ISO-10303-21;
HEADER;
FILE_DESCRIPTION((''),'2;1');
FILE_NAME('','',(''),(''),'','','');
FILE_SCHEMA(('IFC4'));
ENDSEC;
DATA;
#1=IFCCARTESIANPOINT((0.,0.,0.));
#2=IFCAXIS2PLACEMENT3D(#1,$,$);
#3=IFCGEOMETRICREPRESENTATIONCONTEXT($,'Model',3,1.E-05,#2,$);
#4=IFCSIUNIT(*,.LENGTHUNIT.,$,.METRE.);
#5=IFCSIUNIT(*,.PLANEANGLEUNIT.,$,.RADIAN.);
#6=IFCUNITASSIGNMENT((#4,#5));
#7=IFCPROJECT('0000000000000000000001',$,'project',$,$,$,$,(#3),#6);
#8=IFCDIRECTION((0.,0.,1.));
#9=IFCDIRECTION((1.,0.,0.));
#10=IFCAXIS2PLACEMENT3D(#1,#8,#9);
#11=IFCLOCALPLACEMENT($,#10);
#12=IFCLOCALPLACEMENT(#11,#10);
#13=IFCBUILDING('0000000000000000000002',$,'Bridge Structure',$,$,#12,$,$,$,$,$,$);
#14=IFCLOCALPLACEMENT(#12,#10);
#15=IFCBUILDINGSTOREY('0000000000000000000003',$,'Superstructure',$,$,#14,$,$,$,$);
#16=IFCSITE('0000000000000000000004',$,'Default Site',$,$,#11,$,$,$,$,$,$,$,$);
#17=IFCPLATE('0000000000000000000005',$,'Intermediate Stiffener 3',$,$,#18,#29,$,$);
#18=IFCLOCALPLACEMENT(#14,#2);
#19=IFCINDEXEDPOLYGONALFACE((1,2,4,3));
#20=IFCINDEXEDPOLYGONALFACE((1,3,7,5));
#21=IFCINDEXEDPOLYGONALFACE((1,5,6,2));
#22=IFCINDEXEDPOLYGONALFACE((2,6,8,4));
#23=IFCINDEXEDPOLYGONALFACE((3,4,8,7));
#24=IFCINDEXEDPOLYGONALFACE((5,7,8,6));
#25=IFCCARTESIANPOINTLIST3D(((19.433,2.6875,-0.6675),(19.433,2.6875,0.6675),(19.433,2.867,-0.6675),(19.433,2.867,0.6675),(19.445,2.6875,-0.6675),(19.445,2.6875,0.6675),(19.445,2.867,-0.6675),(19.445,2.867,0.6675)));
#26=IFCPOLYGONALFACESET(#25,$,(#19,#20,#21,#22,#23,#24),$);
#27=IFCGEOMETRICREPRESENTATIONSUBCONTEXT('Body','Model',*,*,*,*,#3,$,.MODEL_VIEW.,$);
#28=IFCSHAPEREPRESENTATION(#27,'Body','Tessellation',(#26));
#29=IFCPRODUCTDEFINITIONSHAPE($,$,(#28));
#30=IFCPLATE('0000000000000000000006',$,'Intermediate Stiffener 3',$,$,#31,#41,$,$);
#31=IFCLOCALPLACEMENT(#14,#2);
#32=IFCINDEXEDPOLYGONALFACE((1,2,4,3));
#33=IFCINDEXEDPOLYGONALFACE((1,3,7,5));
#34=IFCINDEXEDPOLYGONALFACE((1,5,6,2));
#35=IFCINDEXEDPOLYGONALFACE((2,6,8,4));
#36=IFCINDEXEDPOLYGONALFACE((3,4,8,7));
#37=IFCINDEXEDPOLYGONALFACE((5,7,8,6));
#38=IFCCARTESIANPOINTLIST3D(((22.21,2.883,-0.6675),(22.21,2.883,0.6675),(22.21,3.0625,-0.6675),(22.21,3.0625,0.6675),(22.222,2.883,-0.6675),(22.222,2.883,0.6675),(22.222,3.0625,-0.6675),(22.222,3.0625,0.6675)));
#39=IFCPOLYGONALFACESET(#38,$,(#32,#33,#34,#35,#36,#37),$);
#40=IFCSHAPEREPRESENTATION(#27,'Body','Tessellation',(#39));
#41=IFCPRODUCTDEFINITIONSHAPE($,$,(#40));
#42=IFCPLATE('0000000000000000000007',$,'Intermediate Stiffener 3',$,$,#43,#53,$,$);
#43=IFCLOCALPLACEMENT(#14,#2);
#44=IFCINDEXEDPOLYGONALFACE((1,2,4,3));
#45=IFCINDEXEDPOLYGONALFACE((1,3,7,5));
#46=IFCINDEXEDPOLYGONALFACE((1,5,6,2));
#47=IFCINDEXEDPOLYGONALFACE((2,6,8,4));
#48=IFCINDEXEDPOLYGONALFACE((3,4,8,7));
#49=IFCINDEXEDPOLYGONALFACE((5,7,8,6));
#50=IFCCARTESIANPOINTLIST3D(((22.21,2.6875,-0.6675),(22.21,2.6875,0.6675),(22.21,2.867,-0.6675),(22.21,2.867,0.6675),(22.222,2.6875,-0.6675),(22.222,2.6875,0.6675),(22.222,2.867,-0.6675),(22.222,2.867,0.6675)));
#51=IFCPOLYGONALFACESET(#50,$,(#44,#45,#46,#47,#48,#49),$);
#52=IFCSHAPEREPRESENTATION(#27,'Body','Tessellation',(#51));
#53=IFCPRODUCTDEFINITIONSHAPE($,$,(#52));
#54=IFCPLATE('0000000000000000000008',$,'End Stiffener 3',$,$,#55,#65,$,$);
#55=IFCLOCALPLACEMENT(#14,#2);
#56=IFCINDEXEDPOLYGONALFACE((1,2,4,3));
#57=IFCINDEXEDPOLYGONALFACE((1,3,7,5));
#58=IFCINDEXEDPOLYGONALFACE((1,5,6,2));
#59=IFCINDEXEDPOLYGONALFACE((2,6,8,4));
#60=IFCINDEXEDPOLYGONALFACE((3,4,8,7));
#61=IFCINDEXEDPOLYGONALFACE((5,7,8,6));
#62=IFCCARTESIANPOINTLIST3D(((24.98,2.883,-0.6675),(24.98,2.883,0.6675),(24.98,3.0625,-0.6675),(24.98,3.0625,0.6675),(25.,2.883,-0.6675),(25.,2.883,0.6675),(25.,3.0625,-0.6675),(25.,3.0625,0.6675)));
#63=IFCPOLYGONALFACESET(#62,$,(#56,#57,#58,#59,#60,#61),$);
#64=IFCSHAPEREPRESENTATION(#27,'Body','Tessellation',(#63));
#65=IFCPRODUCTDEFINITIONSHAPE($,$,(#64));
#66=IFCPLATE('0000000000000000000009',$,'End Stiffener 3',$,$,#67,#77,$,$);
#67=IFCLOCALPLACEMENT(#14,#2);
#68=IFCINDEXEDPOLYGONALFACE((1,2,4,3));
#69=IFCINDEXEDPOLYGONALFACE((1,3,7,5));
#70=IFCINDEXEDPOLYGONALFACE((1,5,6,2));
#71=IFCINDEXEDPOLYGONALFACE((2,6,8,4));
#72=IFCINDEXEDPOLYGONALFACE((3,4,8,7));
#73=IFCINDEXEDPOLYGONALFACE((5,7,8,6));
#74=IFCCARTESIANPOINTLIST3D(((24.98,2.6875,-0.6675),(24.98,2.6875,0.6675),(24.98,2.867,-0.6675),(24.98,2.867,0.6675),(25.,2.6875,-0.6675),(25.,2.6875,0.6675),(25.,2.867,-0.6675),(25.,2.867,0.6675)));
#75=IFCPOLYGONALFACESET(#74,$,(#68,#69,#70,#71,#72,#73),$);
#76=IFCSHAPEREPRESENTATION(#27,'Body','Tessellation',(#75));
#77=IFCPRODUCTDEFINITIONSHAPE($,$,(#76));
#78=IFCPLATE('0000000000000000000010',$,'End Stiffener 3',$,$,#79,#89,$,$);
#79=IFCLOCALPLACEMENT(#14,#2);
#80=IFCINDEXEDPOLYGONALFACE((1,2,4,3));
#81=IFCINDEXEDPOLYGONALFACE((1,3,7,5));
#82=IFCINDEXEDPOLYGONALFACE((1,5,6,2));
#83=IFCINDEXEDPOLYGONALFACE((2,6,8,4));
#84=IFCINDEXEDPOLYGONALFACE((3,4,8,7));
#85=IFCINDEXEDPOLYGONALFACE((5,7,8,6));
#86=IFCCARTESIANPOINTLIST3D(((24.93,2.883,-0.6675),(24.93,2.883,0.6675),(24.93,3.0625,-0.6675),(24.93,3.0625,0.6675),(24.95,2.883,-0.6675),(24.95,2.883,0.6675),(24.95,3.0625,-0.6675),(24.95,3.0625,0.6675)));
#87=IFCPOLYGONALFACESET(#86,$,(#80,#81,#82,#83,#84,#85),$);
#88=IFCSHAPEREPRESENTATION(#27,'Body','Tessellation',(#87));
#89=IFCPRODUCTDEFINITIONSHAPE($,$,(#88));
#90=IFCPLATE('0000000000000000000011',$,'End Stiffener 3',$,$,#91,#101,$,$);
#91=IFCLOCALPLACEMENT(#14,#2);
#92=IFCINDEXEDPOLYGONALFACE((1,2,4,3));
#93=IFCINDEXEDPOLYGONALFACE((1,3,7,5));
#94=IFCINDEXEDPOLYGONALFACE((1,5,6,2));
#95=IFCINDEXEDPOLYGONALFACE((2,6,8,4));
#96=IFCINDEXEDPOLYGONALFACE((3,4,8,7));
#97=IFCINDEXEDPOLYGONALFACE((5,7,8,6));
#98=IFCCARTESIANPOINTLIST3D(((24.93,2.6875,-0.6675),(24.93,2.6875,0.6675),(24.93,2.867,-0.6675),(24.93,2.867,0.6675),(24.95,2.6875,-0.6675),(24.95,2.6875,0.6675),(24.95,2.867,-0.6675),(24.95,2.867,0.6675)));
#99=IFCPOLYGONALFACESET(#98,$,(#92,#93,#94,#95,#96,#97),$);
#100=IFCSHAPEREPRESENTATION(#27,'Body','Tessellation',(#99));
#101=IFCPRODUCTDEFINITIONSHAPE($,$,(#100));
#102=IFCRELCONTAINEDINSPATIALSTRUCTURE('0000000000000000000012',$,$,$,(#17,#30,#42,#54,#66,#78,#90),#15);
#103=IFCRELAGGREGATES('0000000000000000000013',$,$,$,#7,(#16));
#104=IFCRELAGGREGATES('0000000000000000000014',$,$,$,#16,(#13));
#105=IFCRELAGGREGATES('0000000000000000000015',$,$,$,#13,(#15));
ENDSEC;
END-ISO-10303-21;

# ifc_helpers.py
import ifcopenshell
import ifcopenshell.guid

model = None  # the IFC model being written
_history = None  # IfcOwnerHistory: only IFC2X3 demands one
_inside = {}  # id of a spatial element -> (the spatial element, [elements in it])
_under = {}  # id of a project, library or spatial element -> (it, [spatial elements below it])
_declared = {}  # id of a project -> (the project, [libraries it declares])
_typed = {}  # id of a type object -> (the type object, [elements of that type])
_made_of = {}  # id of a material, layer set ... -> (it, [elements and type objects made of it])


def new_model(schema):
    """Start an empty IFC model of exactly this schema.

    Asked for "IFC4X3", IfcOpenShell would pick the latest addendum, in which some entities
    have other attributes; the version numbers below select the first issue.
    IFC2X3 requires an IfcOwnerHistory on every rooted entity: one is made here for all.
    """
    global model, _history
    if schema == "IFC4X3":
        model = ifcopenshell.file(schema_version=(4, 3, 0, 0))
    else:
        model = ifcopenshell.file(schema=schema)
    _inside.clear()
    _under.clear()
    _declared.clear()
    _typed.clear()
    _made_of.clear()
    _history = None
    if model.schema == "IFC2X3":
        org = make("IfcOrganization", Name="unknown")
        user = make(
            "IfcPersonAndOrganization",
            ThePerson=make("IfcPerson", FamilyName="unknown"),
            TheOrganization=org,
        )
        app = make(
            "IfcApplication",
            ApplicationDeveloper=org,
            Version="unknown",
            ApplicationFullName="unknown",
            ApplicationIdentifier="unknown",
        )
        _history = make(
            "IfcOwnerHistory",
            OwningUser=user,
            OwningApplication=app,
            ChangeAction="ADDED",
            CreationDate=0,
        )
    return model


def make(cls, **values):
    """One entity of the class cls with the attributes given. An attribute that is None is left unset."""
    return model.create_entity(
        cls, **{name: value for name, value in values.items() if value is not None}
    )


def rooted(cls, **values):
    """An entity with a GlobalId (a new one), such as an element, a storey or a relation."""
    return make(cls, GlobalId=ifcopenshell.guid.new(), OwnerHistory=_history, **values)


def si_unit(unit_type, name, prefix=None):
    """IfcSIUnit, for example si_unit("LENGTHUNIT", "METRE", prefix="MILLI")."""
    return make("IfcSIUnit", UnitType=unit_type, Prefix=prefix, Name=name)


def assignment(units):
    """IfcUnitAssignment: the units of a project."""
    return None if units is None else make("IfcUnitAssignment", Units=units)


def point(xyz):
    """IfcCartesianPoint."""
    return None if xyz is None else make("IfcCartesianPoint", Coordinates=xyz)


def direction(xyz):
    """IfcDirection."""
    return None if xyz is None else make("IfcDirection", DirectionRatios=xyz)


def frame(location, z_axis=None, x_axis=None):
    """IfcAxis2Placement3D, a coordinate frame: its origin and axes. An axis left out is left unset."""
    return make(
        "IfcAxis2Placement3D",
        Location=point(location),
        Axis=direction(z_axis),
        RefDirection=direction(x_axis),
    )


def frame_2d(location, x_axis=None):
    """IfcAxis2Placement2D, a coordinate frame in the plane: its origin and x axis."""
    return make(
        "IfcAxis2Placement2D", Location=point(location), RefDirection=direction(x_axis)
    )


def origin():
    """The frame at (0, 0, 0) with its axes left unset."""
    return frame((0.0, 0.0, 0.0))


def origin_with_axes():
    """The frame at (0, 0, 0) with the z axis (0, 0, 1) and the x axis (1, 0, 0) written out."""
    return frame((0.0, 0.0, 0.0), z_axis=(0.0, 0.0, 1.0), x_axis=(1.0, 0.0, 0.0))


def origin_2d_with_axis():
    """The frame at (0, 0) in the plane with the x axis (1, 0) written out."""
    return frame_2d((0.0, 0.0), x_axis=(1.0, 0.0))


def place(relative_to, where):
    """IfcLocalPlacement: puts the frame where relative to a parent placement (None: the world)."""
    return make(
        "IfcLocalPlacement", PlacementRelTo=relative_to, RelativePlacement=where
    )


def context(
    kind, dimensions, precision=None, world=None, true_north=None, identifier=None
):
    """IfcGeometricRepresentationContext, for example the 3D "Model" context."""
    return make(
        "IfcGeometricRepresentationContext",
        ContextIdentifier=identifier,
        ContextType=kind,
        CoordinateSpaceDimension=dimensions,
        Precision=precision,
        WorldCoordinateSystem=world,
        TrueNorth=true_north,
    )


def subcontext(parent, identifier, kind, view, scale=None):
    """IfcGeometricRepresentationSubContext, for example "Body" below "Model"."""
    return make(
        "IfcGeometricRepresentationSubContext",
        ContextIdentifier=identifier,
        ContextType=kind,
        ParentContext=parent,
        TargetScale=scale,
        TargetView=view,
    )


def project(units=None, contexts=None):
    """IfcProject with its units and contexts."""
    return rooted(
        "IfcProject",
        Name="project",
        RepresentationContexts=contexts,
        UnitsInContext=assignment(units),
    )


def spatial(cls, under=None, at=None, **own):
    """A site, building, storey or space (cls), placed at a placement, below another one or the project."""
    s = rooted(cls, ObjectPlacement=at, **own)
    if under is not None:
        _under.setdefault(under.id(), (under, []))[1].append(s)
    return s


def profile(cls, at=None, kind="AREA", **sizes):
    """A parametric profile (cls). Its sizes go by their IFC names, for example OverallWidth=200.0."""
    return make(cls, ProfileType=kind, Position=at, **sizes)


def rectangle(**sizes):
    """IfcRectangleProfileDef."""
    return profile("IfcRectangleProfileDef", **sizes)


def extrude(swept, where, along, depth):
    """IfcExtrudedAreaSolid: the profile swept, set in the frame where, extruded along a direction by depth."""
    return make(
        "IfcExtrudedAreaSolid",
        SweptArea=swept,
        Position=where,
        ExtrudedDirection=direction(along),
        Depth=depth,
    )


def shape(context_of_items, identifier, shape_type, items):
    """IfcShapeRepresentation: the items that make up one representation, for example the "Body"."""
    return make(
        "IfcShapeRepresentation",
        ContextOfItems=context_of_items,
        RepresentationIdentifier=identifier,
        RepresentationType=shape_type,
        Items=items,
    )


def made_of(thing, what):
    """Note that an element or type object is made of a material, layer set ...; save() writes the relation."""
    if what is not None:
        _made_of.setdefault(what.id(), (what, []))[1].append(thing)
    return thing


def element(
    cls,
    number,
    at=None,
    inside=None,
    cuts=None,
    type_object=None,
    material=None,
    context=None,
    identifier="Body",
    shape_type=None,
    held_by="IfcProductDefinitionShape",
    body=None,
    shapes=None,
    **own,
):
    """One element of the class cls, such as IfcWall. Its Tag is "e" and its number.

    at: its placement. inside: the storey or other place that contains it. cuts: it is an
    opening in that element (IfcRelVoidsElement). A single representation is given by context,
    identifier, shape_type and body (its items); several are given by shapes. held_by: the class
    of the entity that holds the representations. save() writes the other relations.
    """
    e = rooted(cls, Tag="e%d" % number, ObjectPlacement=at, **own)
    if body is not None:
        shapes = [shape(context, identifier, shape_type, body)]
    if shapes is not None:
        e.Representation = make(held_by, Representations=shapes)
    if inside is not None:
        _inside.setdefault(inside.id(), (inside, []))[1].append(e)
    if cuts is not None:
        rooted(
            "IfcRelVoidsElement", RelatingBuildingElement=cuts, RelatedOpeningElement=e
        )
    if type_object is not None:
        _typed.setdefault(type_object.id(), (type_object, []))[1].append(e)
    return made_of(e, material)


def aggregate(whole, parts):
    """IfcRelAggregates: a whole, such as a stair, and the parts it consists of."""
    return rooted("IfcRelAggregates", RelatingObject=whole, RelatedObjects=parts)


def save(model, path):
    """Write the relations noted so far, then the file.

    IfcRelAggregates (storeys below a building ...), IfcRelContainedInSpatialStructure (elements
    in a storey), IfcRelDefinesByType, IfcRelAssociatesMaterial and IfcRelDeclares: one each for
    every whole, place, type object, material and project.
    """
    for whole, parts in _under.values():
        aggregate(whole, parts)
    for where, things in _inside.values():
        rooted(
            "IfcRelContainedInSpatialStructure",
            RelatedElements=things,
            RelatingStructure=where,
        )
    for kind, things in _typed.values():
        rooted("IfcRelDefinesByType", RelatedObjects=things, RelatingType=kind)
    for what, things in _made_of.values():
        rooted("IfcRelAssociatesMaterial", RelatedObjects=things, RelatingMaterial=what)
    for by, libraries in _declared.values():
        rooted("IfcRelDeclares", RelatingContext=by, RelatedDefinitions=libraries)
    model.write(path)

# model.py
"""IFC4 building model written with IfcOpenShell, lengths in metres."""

from ifc_helpers import new_model, si_unit, frame, origin, origin_with_axes, origin_2d_with_axis, place, context, subcontext, project, spatial, rectangle, extrude, element, save


model = new_model("IFC4")

# Units and contexts
model_context = context("Model", 3, precision=1e-05, world=origin())
body_context = subcontext(model_context, "Body", "Model", "MODEL_VIEW")
ifc_project = project(units=[si_unit("LENGTHUNIT", "METRE"), si_unit("PLANEANGLEUNIT", "RADIAN")], contexts=[model_context])

# Site, building, storey
site_placement = place(None, origin_with_axes())
site = spatial("IfcSite", under=ifc_project, at=site_placement, Name="Default Site")
building_placement = place(site_placement, origin_with_axes())
building = spatial("IfcBuilding", under=site, at=building_placement, Name="Bridge Structure")
storey_placement = place(building_placement, origin_with_axes())
storey = spatial("IfcBuildingStorey", under=building, at=storey_placement, Name="Superstructure")

# Plates
for number, where, z_axis, x_axis, name in (
    (1, (19.439, 2.7772, -0.6675), (0.0, 0.0, 1.0), (1.0, 0.0, 0.0), "Intermediate Stiffener 3"),
    (2, (22.216, 2.9728, -0.6675), (0.0, 0.0, 1.0), (1.0, 0.0, 0.0), "Intermediate Stiffener 3"),
    (3, (22.216, 2.7772, -0.6675), (0.0, 0.0, 1.0), (1.0, 0.0, 0.0), "Intermediate Stiffener 3"),
):
    element("IfcPlate", number, at=place(storey_placement, frame(where, z_axis=z_axis, x_axis=x_axis)), inside=storey, Name=name, context=body_context, shape_type="SweptSolid", body=[
        extrude(rectangle(XDim=0.012, YDim=0.1795, at=origin_2d_with_axis()), origin_with_axes(), (0.0, 0.0, 1.0), 1.335),
    ])
for number, where, z_axis, x_axis, name in (
    (4, (24.99, 2.9728, -0.6675), (0.0, 0.0, 1.0), (1.0, 0.0, 0.0), "End Stiffener 3"),
    (5, (24.99, 2.7772, -0.6675), (0.0, 0.0, 1.0), (1.0, 0.0, 0.0), "End Stiffener 3"),
    (6, (24.94, 2.9728, -0.6675), (0.0, 0.0, 1.0), (1.0, 0.0, 0.0), "End Stiffener 3"),
    (7, (24.94, 2.7772, -0.6675), (0.0, 0.0, 1.0), (1.0, 0.0, 0.0), "End Stiffener 3"),
):
    element("IfcPlate", number, at=place(storey_placement, frame(where, z_axis=z_axis, x_axis=x_axis)), inside=storey, Name=name, context=body_context, shape_type="SweptSolid", body=[
        extrude(rectangle(XDim=0.02, YDim=0.1795, at=origin_2d_with_axis()), origin_with_axes(), (0.0, 0.0, 1.0), 1.335),
    ])

save(model, "model.ifc")
